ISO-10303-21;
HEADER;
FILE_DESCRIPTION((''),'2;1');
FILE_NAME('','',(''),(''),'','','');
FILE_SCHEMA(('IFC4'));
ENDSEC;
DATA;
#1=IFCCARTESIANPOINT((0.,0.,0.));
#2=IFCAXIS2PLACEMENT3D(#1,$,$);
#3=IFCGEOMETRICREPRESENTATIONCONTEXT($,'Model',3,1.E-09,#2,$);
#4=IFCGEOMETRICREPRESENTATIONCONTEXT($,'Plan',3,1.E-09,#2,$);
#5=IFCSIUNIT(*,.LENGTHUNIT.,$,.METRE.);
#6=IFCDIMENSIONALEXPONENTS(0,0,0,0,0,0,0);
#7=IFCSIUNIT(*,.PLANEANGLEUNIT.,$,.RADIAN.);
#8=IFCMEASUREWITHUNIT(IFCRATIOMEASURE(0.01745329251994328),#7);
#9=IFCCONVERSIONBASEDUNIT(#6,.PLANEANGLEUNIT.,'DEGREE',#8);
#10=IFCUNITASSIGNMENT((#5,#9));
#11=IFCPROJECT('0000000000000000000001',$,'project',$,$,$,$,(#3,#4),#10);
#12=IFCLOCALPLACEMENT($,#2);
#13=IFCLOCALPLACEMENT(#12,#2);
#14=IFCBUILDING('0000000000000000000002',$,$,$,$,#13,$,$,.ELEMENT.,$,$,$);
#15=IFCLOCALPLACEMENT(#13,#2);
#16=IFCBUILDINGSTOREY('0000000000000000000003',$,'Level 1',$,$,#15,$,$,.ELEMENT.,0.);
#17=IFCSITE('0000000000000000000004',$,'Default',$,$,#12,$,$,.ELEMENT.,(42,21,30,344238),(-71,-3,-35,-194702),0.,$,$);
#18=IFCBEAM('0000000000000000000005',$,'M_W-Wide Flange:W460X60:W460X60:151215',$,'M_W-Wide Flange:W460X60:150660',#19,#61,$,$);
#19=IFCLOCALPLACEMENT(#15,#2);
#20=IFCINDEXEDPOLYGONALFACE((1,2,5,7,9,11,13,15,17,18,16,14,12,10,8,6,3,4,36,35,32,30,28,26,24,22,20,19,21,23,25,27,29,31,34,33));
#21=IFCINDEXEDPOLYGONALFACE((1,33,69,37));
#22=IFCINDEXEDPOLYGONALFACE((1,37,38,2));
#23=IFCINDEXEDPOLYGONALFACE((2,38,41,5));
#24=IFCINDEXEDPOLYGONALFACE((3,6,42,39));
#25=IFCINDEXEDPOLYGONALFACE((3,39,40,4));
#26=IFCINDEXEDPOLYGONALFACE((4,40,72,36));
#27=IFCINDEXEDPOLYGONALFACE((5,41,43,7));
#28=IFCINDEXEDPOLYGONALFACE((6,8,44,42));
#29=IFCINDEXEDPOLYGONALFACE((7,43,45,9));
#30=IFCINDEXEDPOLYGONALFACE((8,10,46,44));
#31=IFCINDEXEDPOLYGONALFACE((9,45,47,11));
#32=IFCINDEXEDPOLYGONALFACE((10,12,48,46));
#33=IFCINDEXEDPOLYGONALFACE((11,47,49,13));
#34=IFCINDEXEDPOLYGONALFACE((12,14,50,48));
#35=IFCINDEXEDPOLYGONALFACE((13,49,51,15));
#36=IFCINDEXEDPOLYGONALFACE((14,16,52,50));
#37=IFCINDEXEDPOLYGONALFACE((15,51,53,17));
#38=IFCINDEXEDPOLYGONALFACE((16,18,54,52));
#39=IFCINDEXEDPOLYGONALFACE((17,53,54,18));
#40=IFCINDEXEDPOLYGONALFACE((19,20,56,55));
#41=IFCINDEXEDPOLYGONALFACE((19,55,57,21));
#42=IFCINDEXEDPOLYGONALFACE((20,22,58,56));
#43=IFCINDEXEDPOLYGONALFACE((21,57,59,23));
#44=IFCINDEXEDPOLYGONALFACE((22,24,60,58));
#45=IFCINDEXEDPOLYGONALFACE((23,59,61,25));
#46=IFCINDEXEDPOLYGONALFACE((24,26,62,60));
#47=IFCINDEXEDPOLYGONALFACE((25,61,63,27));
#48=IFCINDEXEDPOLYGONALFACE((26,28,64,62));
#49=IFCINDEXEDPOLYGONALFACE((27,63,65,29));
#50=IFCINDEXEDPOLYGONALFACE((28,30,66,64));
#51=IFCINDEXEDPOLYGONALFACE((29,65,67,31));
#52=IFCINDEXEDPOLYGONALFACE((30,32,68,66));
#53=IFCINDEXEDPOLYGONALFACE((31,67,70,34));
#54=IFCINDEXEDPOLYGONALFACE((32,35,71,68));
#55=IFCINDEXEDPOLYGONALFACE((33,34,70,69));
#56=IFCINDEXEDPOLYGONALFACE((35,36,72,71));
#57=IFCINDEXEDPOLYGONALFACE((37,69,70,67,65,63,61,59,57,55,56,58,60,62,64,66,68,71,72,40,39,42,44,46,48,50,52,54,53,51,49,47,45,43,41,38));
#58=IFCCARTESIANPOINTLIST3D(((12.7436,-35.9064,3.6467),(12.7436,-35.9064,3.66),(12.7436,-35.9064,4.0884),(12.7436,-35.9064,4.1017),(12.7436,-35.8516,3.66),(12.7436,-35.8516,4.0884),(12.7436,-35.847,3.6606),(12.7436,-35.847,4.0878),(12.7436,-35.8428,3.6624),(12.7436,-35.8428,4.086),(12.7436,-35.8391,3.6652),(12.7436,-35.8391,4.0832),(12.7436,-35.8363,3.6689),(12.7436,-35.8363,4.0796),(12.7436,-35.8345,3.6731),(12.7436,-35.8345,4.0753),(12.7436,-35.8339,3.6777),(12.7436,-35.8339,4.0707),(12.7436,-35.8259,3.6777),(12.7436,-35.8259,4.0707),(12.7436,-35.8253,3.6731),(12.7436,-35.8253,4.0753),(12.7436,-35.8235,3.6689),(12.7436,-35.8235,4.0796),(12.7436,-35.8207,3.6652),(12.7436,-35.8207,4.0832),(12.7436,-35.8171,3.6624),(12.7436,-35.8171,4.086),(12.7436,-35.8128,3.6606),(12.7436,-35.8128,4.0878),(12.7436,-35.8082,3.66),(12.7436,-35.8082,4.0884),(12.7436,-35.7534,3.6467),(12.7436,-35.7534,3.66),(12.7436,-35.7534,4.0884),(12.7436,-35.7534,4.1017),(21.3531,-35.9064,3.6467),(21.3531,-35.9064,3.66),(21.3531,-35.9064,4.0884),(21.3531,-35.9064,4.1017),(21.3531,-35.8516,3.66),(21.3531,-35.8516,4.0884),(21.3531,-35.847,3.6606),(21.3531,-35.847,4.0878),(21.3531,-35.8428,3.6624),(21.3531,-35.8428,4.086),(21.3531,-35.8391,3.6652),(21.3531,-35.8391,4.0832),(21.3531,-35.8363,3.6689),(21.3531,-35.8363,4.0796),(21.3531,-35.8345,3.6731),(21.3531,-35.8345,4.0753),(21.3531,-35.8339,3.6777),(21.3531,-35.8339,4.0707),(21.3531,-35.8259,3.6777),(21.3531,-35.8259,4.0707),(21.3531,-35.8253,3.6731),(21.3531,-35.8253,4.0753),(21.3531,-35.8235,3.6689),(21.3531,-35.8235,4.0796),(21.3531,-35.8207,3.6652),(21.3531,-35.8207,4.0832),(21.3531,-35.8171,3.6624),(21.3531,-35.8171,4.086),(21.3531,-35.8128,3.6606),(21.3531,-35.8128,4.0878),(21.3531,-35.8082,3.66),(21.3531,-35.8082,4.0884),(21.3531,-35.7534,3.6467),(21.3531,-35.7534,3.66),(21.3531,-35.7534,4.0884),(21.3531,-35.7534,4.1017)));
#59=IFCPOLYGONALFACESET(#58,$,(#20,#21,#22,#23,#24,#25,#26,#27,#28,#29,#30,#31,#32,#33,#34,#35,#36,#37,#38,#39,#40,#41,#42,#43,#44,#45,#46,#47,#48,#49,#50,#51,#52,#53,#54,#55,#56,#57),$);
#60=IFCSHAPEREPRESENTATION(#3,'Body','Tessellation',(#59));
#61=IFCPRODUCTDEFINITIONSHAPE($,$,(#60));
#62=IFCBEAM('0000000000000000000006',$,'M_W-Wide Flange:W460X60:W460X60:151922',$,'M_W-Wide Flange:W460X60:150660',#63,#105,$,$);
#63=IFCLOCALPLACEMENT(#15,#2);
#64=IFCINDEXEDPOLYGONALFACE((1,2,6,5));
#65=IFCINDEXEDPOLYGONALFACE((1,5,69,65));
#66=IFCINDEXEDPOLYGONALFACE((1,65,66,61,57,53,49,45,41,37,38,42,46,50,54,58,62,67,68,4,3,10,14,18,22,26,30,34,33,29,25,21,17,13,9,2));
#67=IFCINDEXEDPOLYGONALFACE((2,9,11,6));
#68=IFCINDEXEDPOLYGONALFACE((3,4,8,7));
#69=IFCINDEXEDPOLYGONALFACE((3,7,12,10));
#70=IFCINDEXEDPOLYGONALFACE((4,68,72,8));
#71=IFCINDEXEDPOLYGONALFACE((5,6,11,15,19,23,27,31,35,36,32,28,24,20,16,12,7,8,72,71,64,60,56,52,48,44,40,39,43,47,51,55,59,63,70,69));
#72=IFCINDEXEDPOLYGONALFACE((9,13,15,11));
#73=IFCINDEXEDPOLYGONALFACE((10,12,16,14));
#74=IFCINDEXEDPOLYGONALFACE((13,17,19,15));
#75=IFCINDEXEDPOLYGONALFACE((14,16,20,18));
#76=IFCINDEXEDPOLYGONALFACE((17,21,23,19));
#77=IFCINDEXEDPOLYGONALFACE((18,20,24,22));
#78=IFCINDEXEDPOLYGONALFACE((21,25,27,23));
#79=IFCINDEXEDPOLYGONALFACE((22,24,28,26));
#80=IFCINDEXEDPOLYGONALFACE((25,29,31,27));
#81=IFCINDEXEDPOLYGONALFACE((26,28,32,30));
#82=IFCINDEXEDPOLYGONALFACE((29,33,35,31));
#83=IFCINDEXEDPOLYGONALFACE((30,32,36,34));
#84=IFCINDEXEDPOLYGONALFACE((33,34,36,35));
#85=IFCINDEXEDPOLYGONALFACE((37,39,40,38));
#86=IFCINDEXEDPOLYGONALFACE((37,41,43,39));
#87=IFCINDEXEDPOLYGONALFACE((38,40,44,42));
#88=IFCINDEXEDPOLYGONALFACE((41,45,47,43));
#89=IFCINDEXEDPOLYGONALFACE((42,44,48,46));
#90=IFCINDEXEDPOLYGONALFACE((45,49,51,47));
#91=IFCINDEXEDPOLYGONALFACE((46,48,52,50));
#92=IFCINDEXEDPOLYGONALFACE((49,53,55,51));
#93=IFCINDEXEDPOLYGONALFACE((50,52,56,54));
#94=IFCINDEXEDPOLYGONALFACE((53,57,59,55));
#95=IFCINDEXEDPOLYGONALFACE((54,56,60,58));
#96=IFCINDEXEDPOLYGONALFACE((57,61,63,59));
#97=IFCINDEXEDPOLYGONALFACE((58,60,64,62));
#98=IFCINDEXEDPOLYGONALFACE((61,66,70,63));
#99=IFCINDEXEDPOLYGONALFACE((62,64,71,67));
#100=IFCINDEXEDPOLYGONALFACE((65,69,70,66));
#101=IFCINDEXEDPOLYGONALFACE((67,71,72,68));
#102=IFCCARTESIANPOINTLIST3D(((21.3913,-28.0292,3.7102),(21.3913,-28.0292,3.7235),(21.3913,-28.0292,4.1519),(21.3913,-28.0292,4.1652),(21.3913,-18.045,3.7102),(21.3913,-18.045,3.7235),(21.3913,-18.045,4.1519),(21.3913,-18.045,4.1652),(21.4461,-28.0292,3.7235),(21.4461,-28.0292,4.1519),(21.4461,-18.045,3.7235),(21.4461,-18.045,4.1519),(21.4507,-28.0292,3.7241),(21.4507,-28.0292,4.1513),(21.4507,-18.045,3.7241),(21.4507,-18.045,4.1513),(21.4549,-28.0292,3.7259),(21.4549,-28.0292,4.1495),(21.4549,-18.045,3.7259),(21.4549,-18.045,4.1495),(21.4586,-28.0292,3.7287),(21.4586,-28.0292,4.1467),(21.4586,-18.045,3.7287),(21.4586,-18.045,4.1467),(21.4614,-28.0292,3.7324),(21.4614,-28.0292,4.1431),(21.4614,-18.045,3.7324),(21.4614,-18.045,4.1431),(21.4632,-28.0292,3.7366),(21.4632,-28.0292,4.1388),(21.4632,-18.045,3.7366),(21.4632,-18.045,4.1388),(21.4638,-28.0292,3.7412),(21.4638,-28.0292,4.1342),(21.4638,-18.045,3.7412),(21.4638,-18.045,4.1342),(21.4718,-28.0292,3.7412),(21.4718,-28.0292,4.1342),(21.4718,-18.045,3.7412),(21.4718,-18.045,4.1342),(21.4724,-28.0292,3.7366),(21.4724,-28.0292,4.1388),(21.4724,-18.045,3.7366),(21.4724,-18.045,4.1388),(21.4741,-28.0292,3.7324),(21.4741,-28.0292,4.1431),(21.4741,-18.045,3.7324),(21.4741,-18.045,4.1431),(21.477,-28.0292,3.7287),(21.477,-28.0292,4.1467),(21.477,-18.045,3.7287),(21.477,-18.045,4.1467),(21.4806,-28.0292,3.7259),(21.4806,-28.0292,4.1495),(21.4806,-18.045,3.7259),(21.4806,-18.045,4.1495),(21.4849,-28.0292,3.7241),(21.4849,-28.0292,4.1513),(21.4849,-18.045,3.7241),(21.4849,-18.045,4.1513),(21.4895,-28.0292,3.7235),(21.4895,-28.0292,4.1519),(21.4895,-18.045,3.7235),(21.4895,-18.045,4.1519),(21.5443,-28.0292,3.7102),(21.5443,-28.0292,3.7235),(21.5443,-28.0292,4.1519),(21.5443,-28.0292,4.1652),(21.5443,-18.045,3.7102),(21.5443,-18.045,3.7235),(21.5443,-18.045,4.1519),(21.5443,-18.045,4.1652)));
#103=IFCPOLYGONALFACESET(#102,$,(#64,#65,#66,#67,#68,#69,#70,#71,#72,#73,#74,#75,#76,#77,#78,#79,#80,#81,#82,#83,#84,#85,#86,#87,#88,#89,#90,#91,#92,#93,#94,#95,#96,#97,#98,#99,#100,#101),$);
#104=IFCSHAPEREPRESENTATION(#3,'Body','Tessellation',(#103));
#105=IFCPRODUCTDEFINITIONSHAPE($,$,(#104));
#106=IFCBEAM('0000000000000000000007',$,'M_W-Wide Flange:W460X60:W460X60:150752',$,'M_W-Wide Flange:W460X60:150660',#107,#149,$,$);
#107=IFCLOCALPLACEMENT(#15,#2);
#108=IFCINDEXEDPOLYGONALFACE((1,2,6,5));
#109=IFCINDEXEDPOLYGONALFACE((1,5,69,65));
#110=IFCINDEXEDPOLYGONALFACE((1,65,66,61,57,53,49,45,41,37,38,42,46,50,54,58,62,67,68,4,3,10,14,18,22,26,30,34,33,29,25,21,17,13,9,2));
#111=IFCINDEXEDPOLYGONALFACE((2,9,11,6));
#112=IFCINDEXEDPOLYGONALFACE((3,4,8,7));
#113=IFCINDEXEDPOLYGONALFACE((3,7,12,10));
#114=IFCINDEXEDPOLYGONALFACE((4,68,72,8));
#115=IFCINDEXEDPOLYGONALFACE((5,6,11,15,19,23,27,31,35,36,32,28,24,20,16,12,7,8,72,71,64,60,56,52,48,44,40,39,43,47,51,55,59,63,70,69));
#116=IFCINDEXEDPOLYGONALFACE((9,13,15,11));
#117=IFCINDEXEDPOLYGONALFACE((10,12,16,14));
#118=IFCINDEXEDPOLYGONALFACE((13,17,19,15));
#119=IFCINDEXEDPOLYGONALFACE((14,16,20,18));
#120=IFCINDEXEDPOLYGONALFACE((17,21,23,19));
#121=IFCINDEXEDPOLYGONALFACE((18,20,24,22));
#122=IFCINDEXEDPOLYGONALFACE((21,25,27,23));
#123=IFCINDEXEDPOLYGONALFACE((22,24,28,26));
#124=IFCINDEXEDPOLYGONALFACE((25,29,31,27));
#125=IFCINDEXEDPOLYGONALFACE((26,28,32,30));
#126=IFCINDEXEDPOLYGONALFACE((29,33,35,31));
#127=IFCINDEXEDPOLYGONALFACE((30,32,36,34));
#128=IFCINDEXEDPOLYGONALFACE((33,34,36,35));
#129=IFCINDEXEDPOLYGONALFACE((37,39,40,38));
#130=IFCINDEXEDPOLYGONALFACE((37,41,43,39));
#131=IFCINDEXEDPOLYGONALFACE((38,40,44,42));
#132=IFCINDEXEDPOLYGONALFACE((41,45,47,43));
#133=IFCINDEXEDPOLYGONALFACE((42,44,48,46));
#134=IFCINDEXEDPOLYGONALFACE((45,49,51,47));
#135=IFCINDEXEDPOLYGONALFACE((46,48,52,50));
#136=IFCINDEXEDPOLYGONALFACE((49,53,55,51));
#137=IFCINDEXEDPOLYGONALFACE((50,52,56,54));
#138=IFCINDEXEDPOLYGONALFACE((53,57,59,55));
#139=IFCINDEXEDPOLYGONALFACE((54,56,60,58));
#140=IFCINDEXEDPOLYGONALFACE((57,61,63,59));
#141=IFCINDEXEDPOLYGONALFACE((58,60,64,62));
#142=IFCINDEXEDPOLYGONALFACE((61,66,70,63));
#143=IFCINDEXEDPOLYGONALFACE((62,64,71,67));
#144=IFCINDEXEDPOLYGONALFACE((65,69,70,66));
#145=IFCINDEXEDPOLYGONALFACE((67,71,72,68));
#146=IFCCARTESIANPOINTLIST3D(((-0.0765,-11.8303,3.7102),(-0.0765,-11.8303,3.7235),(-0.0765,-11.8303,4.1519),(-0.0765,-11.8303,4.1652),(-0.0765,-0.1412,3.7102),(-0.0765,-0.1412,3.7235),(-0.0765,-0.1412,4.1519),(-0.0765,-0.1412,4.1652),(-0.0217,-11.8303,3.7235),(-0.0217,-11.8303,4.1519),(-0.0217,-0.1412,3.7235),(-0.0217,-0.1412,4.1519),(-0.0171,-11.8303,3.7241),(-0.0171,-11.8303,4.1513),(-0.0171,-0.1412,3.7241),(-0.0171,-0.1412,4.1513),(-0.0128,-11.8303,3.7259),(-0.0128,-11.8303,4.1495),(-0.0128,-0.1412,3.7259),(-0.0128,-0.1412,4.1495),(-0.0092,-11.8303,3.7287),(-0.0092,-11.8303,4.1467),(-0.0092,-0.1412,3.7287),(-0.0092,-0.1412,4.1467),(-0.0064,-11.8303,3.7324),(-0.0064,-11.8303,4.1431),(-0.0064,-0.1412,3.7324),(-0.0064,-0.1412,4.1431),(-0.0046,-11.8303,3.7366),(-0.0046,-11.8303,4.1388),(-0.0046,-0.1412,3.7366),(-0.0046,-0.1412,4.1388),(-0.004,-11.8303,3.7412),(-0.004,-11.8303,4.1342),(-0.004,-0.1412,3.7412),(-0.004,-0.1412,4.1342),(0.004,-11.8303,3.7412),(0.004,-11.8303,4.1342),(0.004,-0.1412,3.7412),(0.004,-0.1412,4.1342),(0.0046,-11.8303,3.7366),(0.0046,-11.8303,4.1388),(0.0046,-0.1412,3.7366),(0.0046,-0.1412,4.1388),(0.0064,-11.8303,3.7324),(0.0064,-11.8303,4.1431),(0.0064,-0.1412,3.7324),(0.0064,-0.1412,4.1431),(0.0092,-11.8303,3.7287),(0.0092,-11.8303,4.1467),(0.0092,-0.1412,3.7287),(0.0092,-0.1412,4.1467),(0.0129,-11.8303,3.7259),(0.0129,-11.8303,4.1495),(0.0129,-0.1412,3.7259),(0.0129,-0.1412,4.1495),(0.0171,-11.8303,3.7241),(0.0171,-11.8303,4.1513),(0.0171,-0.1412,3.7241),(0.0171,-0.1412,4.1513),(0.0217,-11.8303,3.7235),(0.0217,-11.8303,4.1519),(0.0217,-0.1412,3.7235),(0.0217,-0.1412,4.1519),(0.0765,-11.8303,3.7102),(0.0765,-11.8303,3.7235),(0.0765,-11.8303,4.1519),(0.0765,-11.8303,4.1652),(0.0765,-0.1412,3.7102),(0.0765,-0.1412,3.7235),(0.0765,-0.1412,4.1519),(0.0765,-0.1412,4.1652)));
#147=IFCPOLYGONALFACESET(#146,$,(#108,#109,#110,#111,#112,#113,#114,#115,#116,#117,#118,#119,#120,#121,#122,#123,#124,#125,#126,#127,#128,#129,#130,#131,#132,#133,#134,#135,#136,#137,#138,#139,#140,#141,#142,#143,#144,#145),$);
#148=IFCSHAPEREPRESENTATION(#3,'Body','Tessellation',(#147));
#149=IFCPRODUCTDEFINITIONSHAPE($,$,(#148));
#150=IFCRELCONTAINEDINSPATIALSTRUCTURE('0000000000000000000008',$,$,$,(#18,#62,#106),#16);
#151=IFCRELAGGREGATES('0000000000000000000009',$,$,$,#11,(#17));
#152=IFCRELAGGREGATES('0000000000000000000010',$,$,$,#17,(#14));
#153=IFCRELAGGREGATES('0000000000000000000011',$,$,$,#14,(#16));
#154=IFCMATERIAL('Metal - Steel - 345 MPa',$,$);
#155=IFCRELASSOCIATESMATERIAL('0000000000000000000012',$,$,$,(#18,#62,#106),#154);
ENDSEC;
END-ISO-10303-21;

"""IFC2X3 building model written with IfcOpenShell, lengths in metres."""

from ifc_helpers import new_model, entity, si_unit, converted_unit, frame, frame_2d, origin, place, context, project, spatial, polyline, circle_curve, parameter, trimmed, segment, composite_curve, outline, extrude, material, element, save


model = new_model("IFC2X3")

# Units and contexts
model_context = context("Model", 3, precision=1e-09, world=origin())
plan_context = context("Plan", 3, precision=1e-09, world=origin())
ifc_project = project(units=[si_unit("LENGTHUNIT", "METRE"), converted_unit("PLANEANGLEUNIT", "DEGREE", entity("IfcRatioMeasure", 0.01745329251994328), si_unit("PLANEANGLEUNIT", "RADIAN"), dimensions=[0, 0, 0, 0, 0, 0, 0])], contexts=[model_context, plan_context])

# Site, building, storey
site_placement = place(None, origin())
site = spatial("IfcSite", under=ifc_project, at=site_placement, Name="Default", CompositionType="ELEMENT", RefLatitude=(42, 21, 30, 344238), RefLongitude=(-71, -3, -35, -194702), RefElevation=0.0)
building_placement = place(site_placement, origin())
building = spatial("IfcBuilding", under=site, at=building_placement, CompositionType="ELEMENT")
storey_placement = place(building_placement, origin())
storey = spatial("IfcBuildingStorey", under=building, at=storey_placement, Name="Level 1", CompositionType="ELEMENT", Elevation=0.0)

# Beams
ifc_material_1 = material(Name="Metal - Steel - 345 MPa")
beam_1_placement = place(storey_placement, frame((21.4678, -35.8299, 4.2672), z_axis=(0.0, 0.0, 1.0), x_axis=(0.0, 1.0, 0.0)))
element("IfcBeam", 1, at=beam_1_placement, inside=storey, material=ifc_material_1, Name="M_W-Wide Flange:W460X60:W460X60:151215", ObjectType="M_W-Wide Flange:W460X60:150660", context=model_context, shape_type="SweptSolid", body=[
    extrude(outline(composite_curve([segment(polyline([(0.2142, -0.0765), (0.2275, -0.0765)]), True, "CONTINUOUS"), segment(polyline([(0.2275, -0.0765), (0.2275, 0.0765)]), True, "CONTINUOUS"), segment(polyline([(0.2275, 0.0765), (0.2142, 0.0765)]), True, "CONTINUOUS"), segment(polyline([(0.2142, 0.0765), (0.2142, 0.0217)]), True, "CONTINUOUS"), segment(trimmed(circle_curve(frame_2d((0.1965, 0.0217), x_axis=(1.0, 0.0)), 0.0177), [parameter(270.0)], [parameter(360.0)], True, "PARAMETER"), False, "CONTINUOUS"), segment(polyline([(0.1965, 0.004), (-0.1965, 0.004)]), True, "CONTINUOUS"), segment(trimmed(circle_curve(frame_2d((-0.1965, 0.0217), x_axis=(0.0, -1.0)), 0.0177), [parameter(270.0)], [parameter(360.0)], True, "PARAMETER"), False, "CONTINUOUS"), segment(polyline([(-0.2142, 0.0217), (-0.2142, 0.0765)]), True, "CONTINUOUS"), segment(polyline([(-0.2142, 0.0765), (-0.2275, 0.0765)]), True, "CONTINUOUS"), segment(polyline([(-0.2275, 0.0765), (-0.2275, -0.0765)]), True, "CONTINUOUS"), segment(polyline([(-0.2275, -0.0765), (-0.2142, -0.0765)]), True, "CONTINUOUS"), segment(polyline([(-0.2142, -0.0765), (-0.2142, -0.0217)]), True, "CONTINUOUS"), segment(trimmed(circle_curve(frame_2d((-0.1965, -0.0217), x_axis=(-1.0, 0.0)), 0.0177), [parameter(270.0)], [parameter(360.0)], True, "PARAMETER"), False, "CONTINUOUS"), segment(polyline([(-0.1965, -0.004), (0.1965, -0.004)]), True, "CONTINUOUS"), segment(trimmed(circle_curve(frame_2d((0.1965, -0.0217), x_axis=(0.0, 1.0)), 0.0177), [parameter(270.0)], [parameter(0.0)], True, "PARAMETER"), False, "CONTINUOUS"), segment(polyline([(0.2142, -0.0217), (0.2142, -0.0765)]), True, "CONTINUOUS")], self_intersect=False)), frame((0.0, 8.7242, -0.393), z_axis=(0.0, -1.0, 0.0), x_axis=(0.0, 0.0, -1.0)), (0.0, 0.0, 1.0), 8.6095),
])
beam_2_placement = place(storey_placement, frame((21.4678, -28.1704, 4.2672)))
element("IfcBeam", 2, at=beam_2_placement, inside=storey, material=ifc_material_1, Name="M_W-Wide Flange:W460X60:W460X60:151922", ObjectType="M_W-Wide Flange:W460X60:150660", context=model_context, shape_type="SweptSolid", body=[
    extrude(outline(composite_curve([segment(polyline([(-0.0765, -0.2142), (-0.0765, -0.2275)]), True, "CONTINUOUS"), segment(polyline([(-0.0765, -0.2275), (0.0765, -0.2275)]), True, "CONTINUOUS"), segment(polyline([(0.0765, -0.2275), (0.0765, -0.2142)]), True, "CONTINUOUS"), segment(polyline([(0.0765, -0.2142), (0.0217, -0.2142)]), True, "CONTINUOUS"), segment(trimmed(circle_curve(frame_2d((0.0217, -0.1965), x_axis=(0.0, -1.0)), 0.0177), [parameter(270.0)], [parameter(360.0)], True, "PARAMETER"), False, "CONTINUOUS"), segment(polyline([(0.004, -0.1965), (0.004, 0.1965)]), True, "CONTINUOUS"), segment(trimmed(circle_curve(frame_2d((0.0217, 0.1965), x_axis=(-1.0, 0.0)), 0.0177), [parameter(270.0)], [parameter(360.0)], True, "PARAMETER"), False, "CONTINUOUS"), segment(polyline([(0.0217, 0.2142), (0.0765, 0.2142)]), True, "CONTINUOUS"), segment(polyline([(0.0765, 0.2142), (0.0765, 0.2275)]), True, "CONTINUOUS"), segment(polyline([(0.0765, 0.2275), (-0.0765, 0.2275)]), True, "CONTINUOUS"), segment(polyline([(-0.0765, 0.2275), (-0.0765, 0.2142)]), True, "CONTINUOUS"), segment(polyline([(-0.0765, 0.2142), (-0.0217, 0.2142)]), True, "CONTINUOUS"), segment(trimmed(circle_curve(frame_2d((-0.0217, 0.1965), x_axis=(0.0, 1.0)), 0.0177), [parameter(270.0)], [parameter(360.0)], True, "PARAMETER"), False, "CONTINUOUS"), segment(polyline([(-0.004, 0.1965), (-0.004, -0.1965)]), True, "CONTINUOUS"), segment(trimmed(circle_curve(frame_2d((-0.0217, -0.1965), x_axis=(1.0, 0.0)), 0.0177), [parameter(270.0)], [parameter(0.0)], True, "PARAMETER"), False, "CONTINUOUS"), segment(polyline([(-0.0217, -0.2142), (-0.0765, -0.2142)]), True, "CONTINUOUS")], self_intersect=False)), frame((0.0, 0.1412, -0.3295), z_axis=(0.0, -1.0, 0.0), x_axis=(1.0, 0.0, 0.0)), (0.0, 0.0, -1.0), 9.9841),
])
beam_3_placement = place(storey_placement, frame((0.0, 0.0, 4.2672), z_axis=(0.0, 0.0, 1.0), x_axis=(-1.0, 0.0, 0.0)))
element("IfcBeam", 3, at=beam_3_placement, inside=storey, material=ifc_material_1, Name="M_W-Wide Flange:W460X60:W460X60:150752", ObjectType="M_W-Wide Flange:W460X60:150660", context=model_context, shape_type="SweptSolid", body=[
    extrude(outline(composite_curve([segment(polyline([(0.2142, -0.0765), (0.2275, -0.0765)]), True, "CONTINUOUS"), segment(polyline([(0.2275, -0.0765), (0.2275, 0.0765)]), True, "CONTINUOUS"), segment(polyline([(0.2275, 0.0765), (0.2142, 0.0765)]), True, "CONTINUOUS"), segment(polyline([(0.2142, 0.0765), (0.2142, 0.0217)]), True, "CONTINUOUS"), segment(trimmed(circle_curve(frame_2d((0.1965, 0.0217), x_axis=(0.0, 1.0)), 0.0177), [parameter(180.0)], [parameter(270.0)], True, "PARAMETER"), False, "CONTINUOUS"), segment(polyline([(0.1965, 0.004), (-0.1965, 0.004)]), True, "CONTINUOUS"), segment(trimmed(circle_curve(frame_2d((-0.1965, 0.0217), x_axis=(0.0, 1.0)), 0.0177), [parameter(90.0)], [parameter(180.0)], True, "PARAMETER"), False, "CONTINUOUS"), segment(polyline([(-0.2142, 0.0217), (-0.2142, 0.0765)]), True, "CONTINUOUS"), segment(polyline([(-0.2142, 0.0765), (-0.2275, 0.0765)]), True, "CONTINUOUS"), segment(polyline([(-0.2275, 0.0765), (-0.2275, -0.0765)]), True, "CONTINUOUS"), segment(polyline([(-0.2275, -0.0765), (-0.2142, -0.0765)]), True, "CONTINUOUS"), segment(polyline([(-0.2142, -0.0765), (-0.2142, -0.0217)]), True, "CONTINUOUS"), segment(trimmed(circle_curve(frame_2d((-0.1965, -0.0217), x_axis=(0.0, 1.0)), 0.0177), [parameter(360.0)], [parameter(90.0)], True, "PARAMETER"), False, "CONTINUOUS"), segment(polyline([(-0.1965, -0.004), (0.1965, -0.004)]), True, "CONTINUOUS"), segment(trimmed(circle_curve(frame_2d((0.1965, -0.0217), x_axis=(0.0, 1.0)), 0.0177), [parameter(270.0)], [parameter(0.0)], True, "PARAMETER"), False, "CONTINUOUS"), segment(polyline([(0.2142, -0.0217), (0.2142, -0.0765)]), True, "CONTINUOUS")], self_intersect=False)), frame((0.0, 11.8303, -0.3295), z_axis=(0.0, -1.0, 0.0), x_axis=(0.0, 0.0, -1.0)), (0.0, 0.0, 1.0), 11.6891),
])

save(model, "model.ifc")
